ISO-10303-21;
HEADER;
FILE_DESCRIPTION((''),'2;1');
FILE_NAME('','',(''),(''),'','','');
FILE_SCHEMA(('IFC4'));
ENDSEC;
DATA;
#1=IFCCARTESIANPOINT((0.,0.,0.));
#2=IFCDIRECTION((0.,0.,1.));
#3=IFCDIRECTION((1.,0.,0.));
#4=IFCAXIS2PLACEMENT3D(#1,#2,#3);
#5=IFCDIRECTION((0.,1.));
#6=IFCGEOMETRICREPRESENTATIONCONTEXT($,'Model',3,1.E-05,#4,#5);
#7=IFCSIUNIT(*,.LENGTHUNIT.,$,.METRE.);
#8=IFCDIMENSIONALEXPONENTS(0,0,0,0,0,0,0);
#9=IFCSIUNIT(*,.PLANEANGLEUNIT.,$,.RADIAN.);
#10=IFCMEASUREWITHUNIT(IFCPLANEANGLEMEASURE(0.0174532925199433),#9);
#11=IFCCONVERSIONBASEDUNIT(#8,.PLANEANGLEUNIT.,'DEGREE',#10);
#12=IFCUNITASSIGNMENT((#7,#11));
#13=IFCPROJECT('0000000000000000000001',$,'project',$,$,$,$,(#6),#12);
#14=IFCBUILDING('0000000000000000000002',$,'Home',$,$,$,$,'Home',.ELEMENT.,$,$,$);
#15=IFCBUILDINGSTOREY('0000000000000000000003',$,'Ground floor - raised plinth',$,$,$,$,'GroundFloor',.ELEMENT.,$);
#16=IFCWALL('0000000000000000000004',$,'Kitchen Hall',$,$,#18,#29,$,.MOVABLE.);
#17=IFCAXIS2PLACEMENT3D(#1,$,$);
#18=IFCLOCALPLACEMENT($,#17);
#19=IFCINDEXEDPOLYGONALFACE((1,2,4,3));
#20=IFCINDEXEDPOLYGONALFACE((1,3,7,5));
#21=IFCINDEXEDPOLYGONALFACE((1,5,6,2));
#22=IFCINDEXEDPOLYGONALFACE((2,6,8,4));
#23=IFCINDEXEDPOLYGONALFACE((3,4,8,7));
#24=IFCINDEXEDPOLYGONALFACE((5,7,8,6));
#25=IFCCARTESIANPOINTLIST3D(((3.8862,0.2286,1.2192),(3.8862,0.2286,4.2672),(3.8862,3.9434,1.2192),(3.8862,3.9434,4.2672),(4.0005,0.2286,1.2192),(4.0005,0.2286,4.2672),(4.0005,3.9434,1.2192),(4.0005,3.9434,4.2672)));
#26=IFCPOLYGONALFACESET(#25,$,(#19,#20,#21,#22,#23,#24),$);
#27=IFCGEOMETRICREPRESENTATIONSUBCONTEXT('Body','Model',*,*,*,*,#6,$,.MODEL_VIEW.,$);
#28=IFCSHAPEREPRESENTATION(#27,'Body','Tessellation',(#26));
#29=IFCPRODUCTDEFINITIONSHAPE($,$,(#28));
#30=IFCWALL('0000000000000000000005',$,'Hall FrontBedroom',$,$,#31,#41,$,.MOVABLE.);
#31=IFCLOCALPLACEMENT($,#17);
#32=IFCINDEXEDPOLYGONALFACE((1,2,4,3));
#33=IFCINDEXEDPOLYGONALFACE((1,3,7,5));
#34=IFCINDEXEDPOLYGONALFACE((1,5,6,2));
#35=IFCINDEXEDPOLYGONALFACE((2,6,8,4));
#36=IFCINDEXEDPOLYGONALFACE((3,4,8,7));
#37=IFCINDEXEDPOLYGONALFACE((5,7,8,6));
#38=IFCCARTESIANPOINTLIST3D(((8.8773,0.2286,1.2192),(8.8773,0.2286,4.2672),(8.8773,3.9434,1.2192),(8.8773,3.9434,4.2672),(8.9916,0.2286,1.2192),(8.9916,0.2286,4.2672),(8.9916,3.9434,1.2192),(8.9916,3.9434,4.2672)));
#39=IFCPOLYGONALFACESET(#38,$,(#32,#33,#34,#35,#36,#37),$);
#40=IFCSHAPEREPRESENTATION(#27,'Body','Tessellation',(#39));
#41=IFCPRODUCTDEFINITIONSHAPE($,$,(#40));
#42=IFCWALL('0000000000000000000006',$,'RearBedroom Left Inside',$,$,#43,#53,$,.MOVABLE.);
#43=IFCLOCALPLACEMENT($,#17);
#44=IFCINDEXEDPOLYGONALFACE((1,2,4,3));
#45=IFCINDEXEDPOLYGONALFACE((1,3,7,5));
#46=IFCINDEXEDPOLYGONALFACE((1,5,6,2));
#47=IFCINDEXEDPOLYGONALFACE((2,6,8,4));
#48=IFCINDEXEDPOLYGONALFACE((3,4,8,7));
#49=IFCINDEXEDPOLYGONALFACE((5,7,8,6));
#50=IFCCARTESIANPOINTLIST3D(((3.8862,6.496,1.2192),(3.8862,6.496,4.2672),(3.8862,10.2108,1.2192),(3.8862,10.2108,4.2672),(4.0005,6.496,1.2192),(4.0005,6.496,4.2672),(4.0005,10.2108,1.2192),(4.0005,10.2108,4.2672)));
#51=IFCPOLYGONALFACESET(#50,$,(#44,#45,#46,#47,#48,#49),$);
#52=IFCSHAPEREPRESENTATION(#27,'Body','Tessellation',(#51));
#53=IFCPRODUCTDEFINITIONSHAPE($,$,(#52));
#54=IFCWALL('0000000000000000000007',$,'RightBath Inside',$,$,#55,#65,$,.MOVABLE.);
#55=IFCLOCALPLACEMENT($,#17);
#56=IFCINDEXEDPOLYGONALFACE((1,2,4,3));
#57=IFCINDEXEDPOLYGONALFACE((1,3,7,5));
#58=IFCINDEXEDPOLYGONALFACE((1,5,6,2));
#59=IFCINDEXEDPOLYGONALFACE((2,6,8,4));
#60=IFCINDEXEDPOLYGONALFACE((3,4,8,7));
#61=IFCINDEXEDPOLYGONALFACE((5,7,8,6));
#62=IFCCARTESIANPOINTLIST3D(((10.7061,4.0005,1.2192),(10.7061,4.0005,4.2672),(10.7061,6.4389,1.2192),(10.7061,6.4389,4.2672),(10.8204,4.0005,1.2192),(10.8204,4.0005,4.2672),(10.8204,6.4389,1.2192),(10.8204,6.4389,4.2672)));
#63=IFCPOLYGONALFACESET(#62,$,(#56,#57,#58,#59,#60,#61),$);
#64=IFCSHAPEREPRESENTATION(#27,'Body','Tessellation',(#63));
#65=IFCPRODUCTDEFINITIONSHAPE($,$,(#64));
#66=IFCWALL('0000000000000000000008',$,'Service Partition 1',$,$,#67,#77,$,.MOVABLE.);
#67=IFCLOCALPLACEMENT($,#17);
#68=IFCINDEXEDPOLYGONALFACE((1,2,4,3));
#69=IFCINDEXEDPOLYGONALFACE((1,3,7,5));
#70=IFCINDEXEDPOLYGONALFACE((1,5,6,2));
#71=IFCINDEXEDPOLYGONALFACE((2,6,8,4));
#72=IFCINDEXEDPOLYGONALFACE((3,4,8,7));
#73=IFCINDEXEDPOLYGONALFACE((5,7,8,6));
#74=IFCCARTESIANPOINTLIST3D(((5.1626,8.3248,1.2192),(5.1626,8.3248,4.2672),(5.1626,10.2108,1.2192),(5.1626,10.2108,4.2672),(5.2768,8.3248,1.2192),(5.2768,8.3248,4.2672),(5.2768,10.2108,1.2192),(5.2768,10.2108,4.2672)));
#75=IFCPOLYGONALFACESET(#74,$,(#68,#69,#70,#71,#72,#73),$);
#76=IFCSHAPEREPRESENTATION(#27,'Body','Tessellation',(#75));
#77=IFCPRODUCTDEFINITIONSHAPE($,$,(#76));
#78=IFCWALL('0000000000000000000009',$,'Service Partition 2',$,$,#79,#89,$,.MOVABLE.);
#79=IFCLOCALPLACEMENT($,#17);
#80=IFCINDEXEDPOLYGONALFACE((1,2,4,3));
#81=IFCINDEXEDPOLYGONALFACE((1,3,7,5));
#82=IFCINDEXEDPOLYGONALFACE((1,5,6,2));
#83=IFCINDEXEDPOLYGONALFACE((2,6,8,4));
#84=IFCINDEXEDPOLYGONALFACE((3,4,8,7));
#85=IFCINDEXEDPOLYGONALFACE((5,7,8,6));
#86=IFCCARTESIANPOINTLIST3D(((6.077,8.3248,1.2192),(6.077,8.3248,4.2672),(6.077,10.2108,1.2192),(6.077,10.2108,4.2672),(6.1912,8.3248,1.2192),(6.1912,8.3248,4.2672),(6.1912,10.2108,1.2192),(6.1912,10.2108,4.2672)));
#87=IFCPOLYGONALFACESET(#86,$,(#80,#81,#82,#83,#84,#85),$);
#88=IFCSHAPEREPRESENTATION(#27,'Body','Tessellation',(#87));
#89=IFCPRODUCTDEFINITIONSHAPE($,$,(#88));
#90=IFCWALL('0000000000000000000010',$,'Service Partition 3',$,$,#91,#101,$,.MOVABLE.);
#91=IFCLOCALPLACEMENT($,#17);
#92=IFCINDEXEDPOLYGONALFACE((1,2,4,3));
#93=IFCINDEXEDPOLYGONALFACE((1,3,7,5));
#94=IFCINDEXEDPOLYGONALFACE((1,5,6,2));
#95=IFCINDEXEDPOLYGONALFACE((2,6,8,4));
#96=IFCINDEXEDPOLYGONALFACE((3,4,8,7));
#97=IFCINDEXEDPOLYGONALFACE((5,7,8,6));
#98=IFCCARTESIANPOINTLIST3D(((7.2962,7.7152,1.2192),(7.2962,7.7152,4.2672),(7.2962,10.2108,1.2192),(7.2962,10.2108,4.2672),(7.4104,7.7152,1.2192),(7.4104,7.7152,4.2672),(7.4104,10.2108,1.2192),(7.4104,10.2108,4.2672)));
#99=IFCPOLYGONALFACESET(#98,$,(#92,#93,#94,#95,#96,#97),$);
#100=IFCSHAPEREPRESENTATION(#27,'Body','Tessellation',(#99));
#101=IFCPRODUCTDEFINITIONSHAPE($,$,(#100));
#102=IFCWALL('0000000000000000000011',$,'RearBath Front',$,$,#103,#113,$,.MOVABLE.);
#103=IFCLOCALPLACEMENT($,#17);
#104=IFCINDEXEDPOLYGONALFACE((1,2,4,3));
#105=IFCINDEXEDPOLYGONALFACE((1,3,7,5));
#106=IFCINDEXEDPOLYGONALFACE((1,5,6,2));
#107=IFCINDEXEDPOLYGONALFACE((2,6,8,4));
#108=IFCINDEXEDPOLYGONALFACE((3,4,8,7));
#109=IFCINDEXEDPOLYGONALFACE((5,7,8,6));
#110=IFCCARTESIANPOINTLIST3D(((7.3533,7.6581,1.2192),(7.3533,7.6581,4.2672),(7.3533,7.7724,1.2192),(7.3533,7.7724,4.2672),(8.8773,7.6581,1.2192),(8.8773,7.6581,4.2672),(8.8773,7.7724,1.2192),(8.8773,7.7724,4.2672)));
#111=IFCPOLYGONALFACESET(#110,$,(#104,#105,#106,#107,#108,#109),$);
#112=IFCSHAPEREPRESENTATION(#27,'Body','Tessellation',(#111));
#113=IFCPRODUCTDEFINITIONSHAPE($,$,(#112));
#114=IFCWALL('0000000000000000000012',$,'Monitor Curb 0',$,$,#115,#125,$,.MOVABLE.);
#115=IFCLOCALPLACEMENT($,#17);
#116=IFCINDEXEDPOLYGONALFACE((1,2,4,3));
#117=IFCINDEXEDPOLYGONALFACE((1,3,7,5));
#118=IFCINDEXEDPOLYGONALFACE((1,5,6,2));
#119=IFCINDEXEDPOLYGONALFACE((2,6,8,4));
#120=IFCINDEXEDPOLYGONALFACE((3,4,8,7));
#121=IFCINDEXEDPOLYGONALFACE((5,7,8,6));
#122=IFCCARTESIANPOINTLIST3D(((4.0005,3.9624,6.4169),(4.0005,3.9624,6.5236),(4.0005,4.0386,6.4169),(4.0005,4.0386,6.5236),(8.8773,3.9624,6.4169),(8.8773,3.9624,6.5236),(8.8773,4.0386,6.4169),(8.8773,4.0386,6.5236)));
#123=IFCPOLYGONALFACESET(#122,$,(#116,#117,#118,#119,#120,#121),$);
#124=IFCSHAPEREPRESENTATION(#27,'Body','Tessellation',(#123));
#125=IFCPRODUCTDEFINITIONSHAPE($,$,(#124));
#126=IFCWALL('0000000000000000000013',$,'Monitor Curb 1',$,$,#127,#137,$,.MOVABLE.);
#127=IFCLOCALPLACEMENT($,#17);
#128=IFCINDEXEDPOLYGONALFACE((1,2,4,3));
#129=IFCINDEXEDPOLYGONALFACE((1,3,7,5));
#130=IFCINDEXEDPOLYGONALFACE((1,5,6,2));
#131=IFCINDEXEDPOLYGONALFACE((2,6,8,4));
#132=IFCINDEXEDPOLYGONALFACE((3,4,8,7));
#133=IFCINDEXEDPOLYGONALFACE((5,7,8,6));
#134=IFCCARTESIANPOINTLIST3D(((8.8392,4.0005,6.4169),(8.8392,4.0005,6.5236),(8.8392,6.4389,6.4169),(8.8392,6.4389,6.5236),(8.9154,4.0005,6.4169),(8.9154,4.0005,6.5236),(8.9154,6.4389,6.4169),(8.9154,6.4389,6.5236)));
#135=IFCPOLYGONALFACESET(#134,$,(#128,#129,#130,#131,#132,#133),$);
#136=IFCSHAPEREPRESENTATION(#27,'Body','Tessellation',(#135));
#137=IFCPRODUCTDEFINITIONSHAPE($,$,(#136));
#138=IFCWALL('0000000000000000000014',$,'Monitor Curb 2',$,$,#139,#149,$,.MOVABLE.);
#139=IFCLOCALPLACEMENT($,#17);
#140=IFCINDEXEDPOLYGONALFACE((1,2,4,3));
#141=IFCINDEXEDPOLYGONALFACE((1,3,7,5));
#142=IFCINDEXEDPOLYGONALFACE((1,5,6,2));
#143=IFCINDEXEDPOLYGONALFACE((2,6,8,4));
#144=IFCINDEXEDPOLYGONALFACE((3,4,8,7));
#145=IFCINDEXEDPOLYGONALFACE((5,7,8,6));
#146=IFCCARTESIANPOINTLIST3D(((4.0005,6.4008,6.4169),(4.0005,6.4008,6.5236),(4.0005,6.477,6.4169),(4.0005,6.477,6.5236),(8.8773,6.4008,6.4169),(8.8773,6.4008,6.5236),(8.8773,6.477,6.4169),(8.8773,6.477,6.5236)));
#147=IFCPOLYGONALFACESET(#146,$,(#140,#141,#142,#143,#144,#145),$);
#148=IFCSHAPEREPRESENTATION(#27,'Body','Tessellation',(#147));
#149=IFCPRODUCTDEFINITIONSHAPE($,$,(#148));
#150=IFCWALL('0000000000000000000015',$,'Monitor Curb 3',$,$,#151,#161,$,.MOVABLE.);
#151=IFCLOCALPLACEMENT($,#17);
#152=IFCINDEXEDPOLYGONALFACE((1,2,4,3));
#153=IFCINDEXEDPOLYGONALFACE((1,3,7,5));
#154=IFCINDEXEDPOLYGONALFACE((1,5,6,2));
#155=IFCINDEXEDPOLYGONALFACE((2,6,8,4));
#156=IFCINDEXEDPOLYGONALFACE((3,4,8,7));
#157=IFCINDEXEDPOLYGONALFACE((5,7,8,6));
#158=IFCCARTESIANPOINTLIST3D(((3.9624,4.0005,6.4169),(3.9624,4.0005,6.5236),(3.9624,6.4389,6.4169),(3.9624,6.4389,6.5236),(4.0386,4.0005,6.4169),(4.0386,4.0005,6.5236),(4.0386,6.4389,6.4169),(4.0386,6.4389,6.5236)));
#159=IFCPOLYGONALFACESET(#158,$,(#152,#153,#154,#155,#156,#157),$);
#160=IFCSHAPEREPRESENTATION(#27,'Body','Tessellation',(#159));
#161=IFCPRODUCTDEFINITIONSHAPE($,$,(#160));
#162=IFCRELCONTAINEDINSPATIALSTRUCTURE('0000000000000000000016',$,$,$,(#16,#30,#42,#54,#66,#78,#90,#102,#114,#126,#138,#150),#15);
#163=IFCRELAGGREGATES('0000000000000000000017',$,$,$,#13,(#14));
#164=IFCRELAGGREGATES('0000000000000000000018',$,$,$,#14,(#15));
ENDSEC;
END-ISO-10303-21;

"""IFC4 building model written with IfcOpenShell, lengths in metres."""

from ifc_helpers import new_model, entity, si_unit, converted_unit, direction, frame, frame_2d, origin_with_axes, origin_2d_with_axis, place, context, subcontext, project, spatial, rectangle, extrude, element, save


model = new_model("IFC4")

# Units and contexts
model_context = context("Model", 3, precision=1e-05, world=origin_with_axes(), true_north=direction((0.0, 1.0)))
body_context = subcontext(model_context, "Body", "Model", "MODEL_VIEW")
ifc_project = project(units=[si_unit("LENGTHUNIT", "METRE"), converted_unit("PLANEANGLEUNIT", "DEGREE", entity("IfcPlaneAngleMeasure", 0.0174532925199433), si_unit("PLANEANGLEUNIT", "RADIAN"), dimensions=[0, 0, 0, 0, 0, 0, 0])], contexts=[model_context])

# Building, storey
building = spatial("IfcBuilding", under=ifc_project, Name="Home", LongName="Home", CompositionType="ELEMENT")
storey = spatial("IfcBuildingStorey", under=building, Name="Ground floor - raised plinth", LongName="GroundFloor", CompositionType="ELEMENT")

# Walls
placement = place(None, origin_with_axes())
element("IfcWall", 1, at=placement, inside=storey, Name="Kitchen Hall", PredefinedType="MOVABLE", context=body_context, shape_type="SweptSolid", body=[
    extrude(rectangle(XDim=3.7147, YDim=0.1143, at=frame_2d((0.0, 0.0), x_axis=(0.0, 1.0))), frame((3.9434, 2.086, 1.2192), z_axis=(0.0, 0.0, 1.0), x_axis=(1.0, 0.0, 0.0)), (0.0, 0.0, 1.0), 3.048),
])
element("IfcWall", 2, at=placement, inside=storey, Name="Hall FrontBedroom", PredefinedType="MOVABLE", context=body_context, shape_type="SweptSolid", body=[
    extrude(rectangle(XDim=3.7147, YDim=0.1143, at=frame_2d((0.0, 0.0), x_axis=(0.0, 1.0))), frame((8.9345, 2.086, 1.2192), z_axis=(0.0, 0.0, 1.0), x_axis=(1.0, 0.0, 0.0)), (0.0, 0.0, 1.0), 3.048),
])
element("IfcWall", 3, at=placement, inside=storey, Name="RearBedroom Left Inside", PredefinedType="MOVABLE", context=body_context, shape_type="SweptSolid", body=[
    extrude(rectangle(XDim=3.7147, YDim=0.1143, at=frame_2d((0.0, 0.0), x_axis=(0.0, 1.0))), frame((3.9434, 8.3534, 1.2192), z_axis=(0.0, 0.0, 1.0), x_axis=(1.0, 0.0, 0.0)), (0.0, 0.0, 1.0), 3.048),
])
element("IfcWall", 4, at=placement, inside=storey, Name="RightBath Inside", PredefinedType="MOVABLE", context=body_context, shape_type="SweptSolid", body=[
    extrude(rectangle(XDim=2.4384, YDim=0.1143, at=frame_2d((0.0, 0.0), x_axis=(0.0, 1.0))), frame((10.7632, 5.2197, 1.2192), z_axis=(0.0, 0.0, 1.0), x_axis=(1.0, 0.0, 0.0)), (0.0, 0.0, 1.0), 3.048),
])
element("IfcWall", 5, at=placement, inside=storey, Name="Service Partition 1", PredefinedType="MOVABLE", context=body_context, shape_type="SweptSolid", body=[
    extrude(rectangle(XDim=1.886, YDim=0.1143, at=frame_2d((0.0, 0.0), x_axis=(0.0, 1.0))), frame((5.2197, 9.2678, 1.2192), z_axis=(0.0, 0.0, 1.0), x_axis=(1.0, 0.0, 0.0)), (0.0, 0.0, 1.0), 3.048),
])
element("IfcWall", 6, at=placement, inside=storey, Name="Service Partition 2", PredefinedType="MOVABLE", context=body_context, shape_type="SweptSolid", body=[
    extrude(rectangle(XDim=1.886, YDim=0.1143, at=frame_2d((0.0, 0.0), x_axis=(0.0, 1.0))), frame((6.1341, 9.2678, 1.2192), z_axis=(0.0, 0.0, 1.0), x_axis=(1.0, 0.0, 0.0)), (0.0, 0.0, 1.0), 3.048),
])
element("IfcWall", 7, at=placement, inside=storey, Name="Service Partition 3", PredefinedType="MOVABLE", context=body_context, shape_type="SweptSolid", body=[
    extrude(rectangle(XDim=2.4956, YDim=0.1143, at=frame_2d((0.0, 0.0), x_axis=(0.0, 1.0))), frame((7.3533, 8.963, 1.2192), z_axis=(0.0, 0.0, 1.0), x_axis=(1.0, 0.0, 0.0)), (0.0, 0.0, 1.0), 3.048),
])
element("IfcWall", 8, at=placement, inside=storey, Name="RearBath Front", PredefinedType="MOVABLE", context=body_context, shape_type="SweptSolid", body=[
    extrude(rectangle(XDim=1.524, YDim=0.1143, at=frame_2d((0.0, 0.0), x_axis=(1.0, 0.0))), frame((8.1153, 7.7153, 1.2192), z_axis=(0.0, 0.0, 1.0), x_axis=(1.0, 0.0, 0.0)), (0.0, 0.0, 1.0), 3.048),
])
element("IfcWall", 9, at=placement, inside=storey, Name="Monitor Curb 0", PredefinedType="MOVABLE", context=body_context, shape_type="SweptSolid", body=[
    extrude(rectangle(XDim=4.8768, YDim=0.0762, at=frame_2d((0.0, 0.0), x_axis=(1.0, 0.0))), frame((6.4389, 4.0005, 6.4169), z_axis=(0.0, 0.0, 1.0), x_axis=(1.0, 0.0, 0.0)), (0.0, 0.0, 1.0), 0.1067),
])
element("IfcWall", 10, at=placement, inside=storey, Name="Monitor Curb 1", PredefinedType="MOVABLE", context=body_context, shape_type="SweptSolid", body=[
    extrude(rectangle(XDim=2.4384, YDim=0.0762, at=frame_2d((0.0, 0.0), x_axis=(0.0, 1.0))), frame((8.8773, 5.2197, 6.4169), z_axis=(0.0, 0.0, 1.0), x_axis=(1.0, 0.0, 0.0)), (0.0, 0.0, 1.0), 0.1067),
])
element("IfcWall", 11, at=placement, inside=storey, Name="Monitor Curb 2", PredefinedType="MOVABLE", context=body_context, shape_type="SweptSolid", body=[
    extrude(rectangle(XDim=4.8768, YDim=0.0762, at=origin_2d_with_axis()), frame((6.4389, 6.4389, 6.4169), z_axis=(0.0, 0.0, 1.0), x_axis=(1.0, 0.0, 0.0)), (0.0, 0.0, 1.0), 0.1067),
])
element("IfcWall", 12, at=placement, inside=storey, Name="Monitor Curb 3", PredefinedType="MOVABLE", context=body_context, shape_type="SweptSolid", body=[
    extrude(rectangle(XDim=2.4384, YDim=0.0762, at=frame_2d((0.0, 0.0), x_axis=(0.0, 1.0))), frame((4.0005, 5.2197, 6.4169), z_axis=(0.0, 0.0, 1.0), x_axis=(1.0, 0.0, 0.0)), (0.0, 0.0, 1.0), 0.1067),
])

save(model, "model.ifc")
